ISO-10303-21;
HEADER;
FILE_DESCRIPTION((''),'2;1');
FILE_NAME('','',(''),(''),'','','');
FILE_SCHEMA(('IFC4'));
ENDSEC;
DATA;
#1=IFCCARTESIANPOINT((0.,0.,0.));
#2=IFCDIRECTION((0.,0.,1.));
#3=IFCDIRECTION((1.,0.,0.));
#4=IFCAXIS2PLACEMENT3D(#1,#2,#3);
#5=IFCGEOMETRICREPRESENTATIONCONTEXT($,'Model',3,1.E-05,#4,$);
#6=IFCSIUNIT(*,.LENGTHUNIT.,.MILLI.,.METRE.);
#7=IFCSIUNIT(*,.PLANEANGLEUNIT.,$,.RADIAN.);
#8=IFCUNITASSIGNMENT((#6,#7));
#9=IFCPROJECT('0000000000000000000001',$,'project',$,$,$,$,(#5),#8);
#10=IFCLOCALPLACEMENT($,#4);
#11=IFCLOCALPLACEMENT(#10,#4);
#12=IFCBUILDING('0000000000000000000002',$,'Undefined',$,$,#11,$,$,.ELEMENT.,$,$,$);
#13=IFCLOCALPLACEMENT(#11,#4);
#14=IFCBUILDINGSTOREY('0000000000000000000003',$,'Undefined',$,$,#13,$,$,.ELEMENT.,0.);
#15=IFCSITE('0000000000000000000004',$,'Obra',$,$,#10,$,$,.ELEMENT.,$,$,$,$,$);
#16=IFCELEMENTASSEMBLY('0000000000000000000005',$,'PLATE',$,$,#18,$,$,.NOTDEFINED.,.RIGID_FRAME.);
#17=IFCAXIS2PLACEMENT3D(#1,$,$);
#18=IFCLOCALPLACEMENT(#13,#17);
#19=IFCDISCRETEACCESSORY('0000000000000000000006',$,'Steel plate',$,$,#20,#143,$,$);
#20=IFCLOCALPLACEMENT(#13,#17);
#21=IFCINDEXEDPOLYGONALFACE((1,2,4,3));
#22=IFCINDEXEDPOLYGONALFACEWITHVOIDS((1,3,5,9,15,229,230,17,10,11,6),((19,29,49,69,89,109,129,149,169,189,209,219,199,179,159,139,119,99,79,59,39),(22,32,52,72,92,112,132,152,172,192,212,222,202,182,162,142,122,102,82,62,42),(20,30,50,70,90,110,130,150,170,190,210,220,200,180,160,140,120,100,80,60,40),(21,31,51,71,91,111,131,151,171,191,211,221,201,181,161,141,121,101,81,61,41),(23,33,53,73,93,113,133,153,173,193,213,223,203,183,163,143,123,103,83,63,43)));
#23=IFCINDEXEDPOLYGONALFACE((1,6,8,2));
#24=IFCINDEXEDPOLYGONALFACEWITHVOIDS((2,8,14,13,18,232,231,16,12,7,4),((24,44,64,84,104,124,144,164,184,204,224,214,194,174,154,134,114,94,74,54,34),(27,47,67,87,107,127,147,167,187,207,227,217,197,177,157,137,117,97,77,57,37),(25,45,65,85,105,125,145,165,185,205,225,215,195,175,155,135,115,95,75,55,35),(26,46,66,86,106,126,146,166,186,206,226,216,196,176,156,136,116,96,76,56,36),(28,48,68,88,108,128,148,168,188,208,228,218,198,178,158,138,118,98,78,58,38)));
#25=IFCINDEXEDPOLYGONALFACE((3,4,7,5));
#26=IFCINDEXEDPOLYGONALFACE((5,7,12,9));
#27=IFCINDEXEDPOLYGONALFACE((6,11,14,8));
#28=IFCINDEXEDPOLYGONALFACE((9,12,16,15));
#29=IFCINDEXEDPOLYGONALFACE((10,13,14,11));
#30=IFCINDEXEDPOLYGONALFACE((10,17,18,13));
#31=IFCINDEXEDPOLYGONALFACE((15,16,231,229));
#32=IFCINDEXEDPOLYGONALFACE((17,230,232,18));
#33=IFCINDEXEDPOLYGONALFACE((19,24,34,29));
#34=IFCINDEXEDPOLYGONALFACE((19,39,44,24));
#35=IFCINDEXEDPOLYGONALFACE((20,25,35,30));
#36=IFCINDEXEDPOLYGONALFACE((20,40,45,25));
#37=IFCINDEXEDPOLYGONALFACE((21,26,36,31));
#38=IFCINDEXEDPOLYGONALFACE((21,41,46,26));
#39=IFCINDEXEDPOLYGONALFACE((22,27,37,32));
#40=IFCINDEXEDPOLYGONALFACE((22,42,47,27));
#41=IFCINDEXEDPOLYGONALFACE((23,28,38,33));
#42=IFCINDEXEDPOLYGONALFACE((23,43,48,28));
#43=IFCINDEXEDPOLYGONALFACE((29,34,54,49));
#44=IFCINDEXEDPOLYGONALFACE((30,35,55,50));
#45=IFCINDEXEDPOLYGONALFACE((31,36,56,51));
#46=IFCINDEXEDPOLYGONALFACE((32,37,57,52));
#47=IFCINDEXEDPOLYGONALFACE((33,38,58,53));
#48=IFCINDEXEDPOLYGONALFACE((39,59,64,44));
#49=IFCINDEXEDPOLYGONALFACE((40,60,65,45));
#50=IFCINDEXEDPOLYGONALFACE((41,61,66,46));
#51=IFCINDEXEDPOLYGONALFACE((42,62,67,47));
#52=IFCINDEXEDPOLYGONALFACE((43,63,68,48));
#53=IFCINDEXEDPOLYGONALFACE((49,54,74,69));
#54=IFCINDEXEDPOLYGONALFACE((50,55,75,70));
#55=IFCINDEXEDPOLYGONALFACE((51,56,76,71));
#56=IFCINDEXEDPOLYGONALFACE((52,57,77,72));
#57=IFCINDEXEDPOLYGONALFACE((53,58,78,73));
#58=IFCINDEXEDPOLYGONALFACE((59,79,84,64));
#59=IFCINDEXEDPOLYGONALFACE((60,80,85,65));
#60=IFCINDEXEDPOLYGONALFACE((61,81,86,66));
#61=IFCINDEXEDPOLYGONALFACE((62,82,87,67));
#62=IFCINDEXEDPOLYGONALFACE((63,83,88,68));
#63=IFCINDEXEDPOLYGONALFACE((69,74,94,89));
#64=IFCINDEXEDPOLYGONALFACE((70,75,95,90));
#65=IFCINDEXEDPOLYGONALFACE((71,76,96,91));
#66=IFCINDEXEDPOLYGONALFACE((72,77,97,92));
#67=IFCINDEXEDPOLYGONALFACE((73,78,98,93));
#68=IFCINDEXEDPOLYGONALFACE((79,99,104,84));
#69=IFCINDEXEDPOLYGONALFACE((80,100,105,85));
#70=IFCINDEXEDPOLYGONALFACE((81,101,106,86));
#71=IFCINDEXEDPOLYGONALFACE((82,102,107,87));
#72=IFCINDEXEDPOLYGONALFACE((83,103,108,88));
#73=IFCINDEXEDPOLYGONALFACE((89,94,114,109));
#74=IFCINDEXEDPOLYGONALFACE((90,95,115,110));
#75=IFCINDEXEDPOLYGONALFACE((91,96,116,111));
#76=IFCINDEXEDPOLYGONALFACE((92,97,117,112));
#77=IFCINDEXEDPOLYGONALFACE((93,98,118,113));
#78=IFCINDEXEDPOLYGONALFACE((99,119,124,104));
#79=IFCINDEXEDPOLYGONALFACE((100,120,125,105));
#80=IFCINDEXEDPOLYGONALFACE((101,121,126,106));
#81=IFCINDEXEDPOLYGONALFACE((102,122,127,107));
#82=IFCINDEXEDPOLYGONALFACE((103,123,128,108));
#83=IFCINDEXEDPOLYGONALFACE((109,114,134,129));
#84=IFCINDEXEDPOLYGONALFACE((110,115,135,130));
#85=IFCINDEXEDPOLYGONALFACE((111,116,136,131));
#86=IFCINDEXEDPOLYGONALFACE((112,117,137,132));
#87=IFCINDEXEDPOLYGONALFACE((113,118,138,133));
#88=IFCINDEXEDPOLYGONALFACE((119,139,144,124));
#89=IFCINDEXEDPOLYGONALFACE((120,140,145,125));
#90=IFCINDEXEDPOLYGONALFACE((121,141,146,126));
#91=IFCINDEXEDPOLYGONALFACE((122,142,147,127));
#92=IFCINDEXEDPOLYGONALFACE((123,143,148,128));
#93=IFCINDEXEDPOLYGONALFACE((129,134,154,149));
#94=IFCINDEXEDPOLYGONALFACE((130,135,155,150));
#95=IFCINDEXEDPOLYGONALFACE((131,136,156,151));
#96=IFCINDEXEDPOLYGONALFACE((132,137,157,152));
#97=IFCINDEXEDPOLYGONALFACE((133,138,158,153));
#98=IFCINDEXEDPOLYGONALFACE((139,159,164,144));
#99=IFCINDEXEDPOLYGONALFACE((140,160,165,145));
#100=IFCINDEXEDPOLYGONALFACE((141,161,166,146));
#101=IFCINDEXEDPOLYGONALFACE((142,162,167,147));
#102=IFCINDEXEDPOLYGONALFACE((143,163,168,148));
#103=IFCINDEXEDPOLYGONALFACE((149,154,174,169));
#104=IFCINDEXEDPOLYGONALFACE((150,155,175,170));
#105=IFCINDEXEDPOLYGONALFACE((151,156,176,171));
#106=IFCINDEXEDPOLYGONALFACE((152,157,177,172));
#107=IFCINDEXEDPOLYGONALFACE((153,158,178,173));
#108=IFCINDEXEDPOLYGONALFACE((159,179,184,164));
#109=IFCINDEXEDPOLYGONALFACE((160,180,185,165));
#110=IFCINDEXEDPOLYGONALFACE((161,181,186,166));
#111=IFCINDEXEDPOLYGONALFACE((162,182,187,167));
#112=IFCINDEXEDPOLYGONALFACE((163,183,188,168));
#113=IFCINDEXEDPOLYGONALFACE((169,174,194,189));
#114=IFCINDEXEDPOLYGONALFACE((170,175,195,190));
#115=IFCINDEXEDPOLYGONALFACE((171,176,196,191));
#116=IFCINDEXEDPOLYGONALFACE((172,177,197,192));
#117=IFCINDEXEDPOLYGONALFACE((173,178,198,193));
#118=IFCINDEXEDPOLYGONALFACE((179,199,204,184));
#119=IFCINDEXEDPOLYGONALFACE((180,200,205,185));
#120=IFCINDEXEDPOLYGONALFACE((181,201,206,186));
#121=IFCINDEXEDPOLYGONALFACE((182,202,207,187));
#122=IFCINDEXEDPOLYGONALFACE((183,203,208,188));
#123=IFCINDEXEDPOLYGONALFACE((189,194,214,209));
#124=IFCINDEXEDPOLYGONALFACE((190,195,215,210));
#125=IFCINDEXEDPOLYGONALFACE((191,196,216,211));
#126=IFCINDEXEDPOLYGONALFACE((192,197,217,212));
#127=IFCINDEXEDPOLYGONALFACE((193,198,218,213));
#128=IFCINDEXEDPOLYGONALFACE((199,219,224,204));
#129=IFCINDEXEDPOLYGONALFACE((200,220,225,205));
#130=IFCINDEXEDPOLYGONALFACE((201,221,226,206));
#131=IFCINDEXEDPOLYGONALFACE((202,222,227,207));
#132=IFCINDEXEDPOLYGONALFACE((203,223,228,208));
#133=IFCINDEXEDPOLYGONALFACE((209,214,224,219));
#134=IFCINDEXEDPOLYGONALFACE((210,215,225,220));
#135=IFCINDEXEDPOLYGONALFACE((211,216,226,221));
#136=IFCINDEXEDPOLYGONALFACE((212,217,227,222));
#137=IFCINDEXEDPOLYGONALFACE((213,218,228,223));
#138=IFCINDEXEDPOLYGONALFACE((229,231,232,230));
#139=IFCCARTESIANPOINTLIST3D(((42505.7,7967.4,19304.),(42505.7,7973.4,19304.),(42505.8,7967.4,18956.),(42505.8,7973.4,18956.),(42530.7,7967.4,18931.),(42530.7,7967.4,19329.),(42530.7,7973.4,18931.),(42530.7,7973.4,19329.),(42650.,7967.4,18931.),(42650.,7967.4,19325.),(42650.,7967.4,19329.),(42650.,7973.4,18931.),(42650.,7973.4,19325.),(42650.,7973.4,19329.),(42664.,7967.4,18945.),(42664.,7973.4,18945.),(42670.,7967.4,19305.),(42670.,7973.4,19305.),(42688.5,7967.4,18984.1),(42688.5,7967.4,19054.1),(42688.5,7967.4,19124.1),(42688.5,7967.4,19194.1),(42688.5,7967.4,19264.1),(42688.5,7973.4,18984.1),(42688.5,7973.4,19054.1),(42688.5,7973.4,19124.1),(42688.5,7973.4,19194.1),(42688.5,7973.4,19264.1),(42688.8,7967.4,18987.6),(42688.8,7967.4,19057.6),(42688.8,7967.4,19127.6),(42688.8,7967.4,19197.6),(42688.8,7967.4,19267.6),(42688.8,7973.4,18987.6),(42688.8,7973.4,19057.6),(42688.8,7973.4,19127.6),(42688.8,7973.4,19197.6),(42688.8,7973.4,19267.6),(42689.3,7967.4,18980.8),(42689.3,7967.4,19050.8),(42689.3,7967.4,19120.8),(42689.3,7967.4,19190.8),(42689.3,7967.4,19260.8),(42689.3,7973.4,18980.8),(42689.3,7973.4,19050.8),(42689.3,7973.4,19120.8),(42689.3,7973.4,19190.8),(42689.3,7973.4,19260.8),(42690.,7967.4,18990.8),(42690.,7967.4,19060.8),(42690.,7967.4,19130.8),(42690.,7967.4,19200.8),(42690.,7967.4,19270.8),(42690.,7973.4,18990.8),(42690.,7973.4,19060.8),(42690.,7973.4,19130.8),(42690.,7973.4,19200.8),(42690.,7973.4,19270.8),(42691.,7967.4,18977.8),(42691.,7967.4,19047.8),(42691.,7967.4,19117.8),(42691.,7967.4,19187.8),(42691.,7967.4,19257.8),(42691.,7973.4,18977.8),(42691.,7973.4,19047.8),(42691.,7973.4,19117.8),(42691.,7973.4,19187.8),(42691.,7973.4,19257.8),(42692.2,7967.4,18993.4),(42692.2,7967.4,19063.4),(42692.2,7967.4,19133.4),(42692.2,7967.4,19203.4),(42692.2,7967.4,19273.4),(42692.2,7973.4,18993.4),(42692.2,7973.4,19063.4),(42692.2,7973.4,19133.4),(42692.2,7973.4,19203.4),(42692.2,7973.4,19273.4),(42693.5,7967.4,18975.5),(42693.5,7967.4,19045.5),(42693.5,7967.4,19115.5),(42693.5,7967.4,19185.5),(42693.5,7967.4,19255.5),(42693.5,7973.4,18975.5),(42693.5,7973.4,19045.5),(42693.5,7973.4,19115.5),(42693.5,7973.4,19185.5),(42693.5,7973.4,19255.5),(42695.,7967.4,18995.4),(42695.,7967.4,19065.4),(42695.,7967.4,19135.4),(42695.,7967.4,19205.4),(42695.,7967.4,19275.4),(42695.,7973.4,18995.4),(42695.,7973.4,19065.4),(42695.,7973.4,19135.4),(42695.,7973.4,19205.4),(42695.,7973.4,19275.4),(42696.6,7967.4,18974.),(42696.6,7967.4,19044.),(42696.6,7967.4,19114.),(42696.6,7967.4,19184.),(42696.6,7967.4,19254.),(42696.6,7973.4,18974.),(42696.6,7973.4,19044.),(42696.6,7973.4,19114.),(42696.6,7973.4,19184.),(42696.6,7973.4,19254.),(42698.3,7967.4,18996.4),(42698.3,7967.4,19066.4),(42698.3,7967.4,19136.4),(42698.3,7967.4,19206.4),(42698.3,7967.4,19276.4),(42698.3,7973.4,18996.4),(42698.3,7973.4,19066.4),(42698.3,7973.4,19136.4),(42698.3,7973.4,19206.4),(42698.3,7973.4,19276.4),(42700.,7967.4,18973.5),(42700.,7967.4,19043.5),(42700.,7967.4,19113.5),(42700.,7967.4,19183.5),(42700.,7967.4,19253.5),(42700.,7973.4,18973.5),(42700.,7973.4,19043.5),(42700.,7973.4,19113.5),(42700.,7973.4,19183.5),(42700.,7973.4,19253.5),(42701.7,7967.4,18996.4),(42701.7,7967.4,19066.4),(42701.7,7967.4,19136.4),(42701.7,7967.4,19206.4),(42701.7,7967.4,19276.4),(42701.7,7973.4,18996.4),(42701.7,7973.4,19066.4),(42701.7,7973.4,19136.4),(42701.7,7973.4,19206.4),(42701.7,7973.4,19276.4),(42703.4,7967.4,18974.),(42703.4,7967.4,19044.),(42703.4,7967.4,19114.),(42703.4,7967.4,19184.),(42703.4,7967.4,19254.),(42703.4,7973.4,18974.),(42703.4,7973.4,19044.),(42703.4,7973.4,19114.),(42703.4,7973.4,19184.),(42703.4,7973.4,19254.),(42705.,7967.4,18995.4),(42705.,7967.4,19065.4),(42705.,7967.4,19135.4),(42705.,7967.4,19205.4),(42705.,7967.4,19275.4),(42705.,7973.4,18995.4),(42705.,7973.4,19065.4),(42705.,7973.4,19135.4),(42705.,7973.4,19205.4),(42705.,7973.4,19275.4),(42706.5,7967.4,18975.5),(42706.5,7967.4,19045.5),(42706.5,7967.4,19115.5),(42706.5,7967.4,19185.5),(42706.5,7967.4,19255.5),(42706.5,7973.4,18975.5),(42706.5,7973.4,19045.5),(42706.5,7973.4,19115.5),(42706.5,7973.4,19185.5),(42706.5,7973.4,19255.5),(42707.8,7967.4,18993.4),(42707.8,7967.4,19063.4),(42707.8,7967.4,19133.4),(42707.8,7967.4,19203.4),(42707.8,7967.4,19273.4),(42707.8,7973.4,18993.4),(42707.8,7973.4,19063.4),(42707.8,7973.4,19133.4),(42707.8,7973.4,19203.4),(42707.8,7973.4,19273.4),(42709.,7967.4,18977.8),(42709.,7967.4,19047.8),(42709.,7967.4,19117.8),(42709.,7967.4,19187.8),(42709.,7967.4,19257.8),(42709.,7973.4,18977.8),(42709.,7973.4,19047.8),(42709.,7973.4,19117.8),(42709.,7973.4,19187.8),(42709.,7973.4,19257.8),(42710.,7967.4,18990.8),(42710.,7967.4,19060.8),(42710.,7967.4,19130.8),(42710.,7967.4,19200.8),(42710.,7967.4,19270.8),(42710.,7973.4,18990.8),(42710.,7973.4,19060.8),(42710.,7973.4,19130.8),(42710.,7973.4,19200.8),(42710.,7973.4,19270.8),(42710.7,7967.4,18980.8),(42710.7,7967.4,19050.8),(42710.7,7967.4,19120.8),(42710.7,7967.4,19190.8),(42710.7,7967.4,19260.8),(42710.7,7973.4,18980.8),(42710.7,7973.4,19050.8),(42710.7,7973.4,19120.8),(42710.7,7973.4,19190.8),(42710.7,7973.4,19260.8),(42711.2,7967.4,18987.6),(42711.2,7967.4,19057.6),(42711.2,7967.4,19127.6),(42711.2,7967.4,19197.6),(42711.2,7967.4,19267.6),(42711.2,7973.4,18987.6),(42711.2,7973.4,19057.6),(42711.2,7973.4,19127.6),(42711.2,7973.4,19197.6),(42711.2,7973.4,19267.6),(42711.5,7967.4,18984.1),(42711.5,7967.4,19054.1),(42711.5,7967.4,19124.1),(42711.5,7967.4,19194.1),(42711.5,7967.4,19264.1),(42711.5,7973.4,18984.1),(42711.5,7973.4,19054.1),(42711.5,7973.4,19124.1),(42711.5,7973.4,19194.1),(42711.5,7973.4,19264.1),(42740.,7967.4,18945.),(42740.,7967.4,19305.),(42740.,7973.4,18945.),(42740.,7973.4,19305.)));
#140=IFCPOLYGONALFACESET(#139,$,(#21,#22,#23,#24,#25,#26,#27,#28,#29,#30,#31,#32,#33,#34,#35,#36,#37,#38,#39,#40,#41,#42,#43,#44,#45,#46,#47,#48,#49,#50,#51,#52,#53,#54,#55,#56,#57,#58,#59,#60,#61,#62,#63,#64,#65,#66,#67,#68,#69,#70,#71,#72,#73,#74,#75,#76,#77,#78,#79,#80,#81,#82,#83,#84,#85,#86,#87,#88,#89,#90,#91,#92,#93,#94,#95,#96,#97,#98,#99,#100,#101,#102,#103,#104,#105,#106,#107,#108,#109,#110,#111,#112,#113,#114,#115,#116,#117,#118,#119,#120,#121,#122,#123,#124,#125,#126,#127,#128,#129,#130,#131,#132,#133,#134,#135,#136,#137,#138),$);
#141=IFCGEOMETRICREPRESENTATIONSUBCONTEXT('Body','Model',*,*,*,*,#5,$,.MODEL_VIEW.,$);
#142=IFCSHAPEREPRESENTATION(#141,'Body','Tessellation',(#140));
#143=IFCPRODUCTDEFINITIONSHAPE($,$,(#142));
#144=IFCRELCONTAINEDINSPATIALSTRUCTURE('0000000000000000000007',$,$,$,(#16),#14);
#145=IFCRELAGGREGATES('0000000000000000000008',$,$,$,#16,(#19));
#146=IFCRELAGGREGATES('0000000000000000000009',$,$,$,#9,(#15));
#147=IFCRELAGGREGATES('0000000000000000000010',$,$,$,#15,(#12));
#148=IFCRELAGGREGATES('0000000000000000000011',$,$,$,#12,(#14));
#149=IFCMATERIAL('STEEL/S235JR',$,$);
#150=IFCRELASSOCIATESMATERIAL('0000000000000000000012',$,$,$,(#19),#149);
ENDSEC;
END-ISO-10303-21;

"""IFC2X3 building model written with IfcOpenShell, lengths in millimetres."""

from ifc_helpers import new_model, si_unit, frame, origin_with_axes, origin_2d_with_axis, place, context, subcontext, project, spatial, polyline, circle, outline, extrude, source, transform, mapped, material, element, aggregate, save


model = new_model("IFC2X3")

# Units and contexts
model_context = context("Model", 3, precision=1e-05, world=origin_with_axes())
body_context = subcontext(model_context, "Body", "Model", "MODEL_VIEW")
ifc_project = project(units=[si_unit("LENGTHUNIT", "METRE", prefix="MILLI"), si_unit("PLANEANGLEUNIT", "RADIAN")], contexts=[model_context])

# Site, building, storey
site_placement = place(None, origin_with_axes())
site = spatial("IfcSite", under=ifc_project, at=site_placement, Name="Obra", CompositionType="ELEMENT")
building_placement = place(site_placement, origin_with_axes())
building = spatial("IfcBuilding", under=site, at=building_placement, Name="Undefined", CompositionType="ELEMENT")
storey_placement = place(building_placement, origin_with_axes())
storey = spatial("IfcBuildingStorey", under=building, at=storey_placement, Name="Undefined", CompositionType="ELEMENT", Elevation=0.0)

# Shared definitions
ifc_material_1 = material(Name="STEEL/S235JR")

# Element assembly, discrete accessory, opening
assembly_1_placement = place(storey_placement, origin_with_axes())
assembly_1 = element("IfcElementAssembly", 1, at=assembly_1_placement, inside=storey, Name="PLATE", AssemblyPlace="NOTDEFINED", PredefinedType="RIGID_FRAME")
discrete_accessory_1_placement = place(assembly_1_placement, frame((42505.8, 7970.4, 18956.0), z_axis=(0.0, -1.0, 0.0), x_axis=(0.707107, 0.000001, -0.707107)))
discrete_accessory_1 = element("IfcDiscreteAccessory", 2, at=discrete_accessory_1_placement, material=ifc_material_1, Name="Steel plate", context=body_context, shape_type="SweptSolid", body=[
    extrude(outline(polyline([(0.0, 0.0), (35.4, 0.0), (119.7, 84.3), (119.7, 84.3), (119.7, 104.1), (173.4, 157.9), (-81.1, 412.4), (-130.6, 362.9), (-158.9, 362.9), (-161.8, 365.8), (-246.1, 281.4), (-246.1, 246.1), (0.0, 0.0)])), frame((0.0, 0.0, -3.0), z_axis=(0.0, 0.0, 1.0), x_axis=(1.0, 0.0, 0.0)), (0.0, 0.0, 1.0), 6.0),
])
shared_shape_1 = source(origin_with_axes(), body_context, "Body", "SweptSolid", [
    extrude(circle(Radius=11.5, at=origin_2d_with_axis()), frame((0.0, 4.6, 0.0), z_axis=(0.0, 1.0, 0.0), x_axis=(1.0, 0.0, 0.0)), (0.0, 0.0, 1.0), 6.2),
])
opening_1_placement = place(assembly_1_placement, frame((42660.0, 7962.7, 19305.0), z_axis=(1.0, 0.0, 0.0), x_axis=(0.0, 0.0, -1.0)))
element("IfcOpeningElement", 3, at=opening_1_placement, cuts=discrete_accessory_1, ObjectType="Opening", context=body_context, shape_type="MappedRepresentation", body=[
    mapped(shared_shape_1, transform((40.0, 0.0, 40.0))),
    mapped(shared_shape_1, transform((110.0, 0.0, 40.0))),
    mapped(shared_shape_1, transform((180.0, 0.0, 40.0))),
    mapped(shared_shape_1, transform((250.0, 0.0, 40.0))),
    mapped(shared_shape_1, transform((320.0, 0.0, 40.0))),
])
aggregate(assembly_1, [discrete_accessory_1])

save(model, "model.ifc")
